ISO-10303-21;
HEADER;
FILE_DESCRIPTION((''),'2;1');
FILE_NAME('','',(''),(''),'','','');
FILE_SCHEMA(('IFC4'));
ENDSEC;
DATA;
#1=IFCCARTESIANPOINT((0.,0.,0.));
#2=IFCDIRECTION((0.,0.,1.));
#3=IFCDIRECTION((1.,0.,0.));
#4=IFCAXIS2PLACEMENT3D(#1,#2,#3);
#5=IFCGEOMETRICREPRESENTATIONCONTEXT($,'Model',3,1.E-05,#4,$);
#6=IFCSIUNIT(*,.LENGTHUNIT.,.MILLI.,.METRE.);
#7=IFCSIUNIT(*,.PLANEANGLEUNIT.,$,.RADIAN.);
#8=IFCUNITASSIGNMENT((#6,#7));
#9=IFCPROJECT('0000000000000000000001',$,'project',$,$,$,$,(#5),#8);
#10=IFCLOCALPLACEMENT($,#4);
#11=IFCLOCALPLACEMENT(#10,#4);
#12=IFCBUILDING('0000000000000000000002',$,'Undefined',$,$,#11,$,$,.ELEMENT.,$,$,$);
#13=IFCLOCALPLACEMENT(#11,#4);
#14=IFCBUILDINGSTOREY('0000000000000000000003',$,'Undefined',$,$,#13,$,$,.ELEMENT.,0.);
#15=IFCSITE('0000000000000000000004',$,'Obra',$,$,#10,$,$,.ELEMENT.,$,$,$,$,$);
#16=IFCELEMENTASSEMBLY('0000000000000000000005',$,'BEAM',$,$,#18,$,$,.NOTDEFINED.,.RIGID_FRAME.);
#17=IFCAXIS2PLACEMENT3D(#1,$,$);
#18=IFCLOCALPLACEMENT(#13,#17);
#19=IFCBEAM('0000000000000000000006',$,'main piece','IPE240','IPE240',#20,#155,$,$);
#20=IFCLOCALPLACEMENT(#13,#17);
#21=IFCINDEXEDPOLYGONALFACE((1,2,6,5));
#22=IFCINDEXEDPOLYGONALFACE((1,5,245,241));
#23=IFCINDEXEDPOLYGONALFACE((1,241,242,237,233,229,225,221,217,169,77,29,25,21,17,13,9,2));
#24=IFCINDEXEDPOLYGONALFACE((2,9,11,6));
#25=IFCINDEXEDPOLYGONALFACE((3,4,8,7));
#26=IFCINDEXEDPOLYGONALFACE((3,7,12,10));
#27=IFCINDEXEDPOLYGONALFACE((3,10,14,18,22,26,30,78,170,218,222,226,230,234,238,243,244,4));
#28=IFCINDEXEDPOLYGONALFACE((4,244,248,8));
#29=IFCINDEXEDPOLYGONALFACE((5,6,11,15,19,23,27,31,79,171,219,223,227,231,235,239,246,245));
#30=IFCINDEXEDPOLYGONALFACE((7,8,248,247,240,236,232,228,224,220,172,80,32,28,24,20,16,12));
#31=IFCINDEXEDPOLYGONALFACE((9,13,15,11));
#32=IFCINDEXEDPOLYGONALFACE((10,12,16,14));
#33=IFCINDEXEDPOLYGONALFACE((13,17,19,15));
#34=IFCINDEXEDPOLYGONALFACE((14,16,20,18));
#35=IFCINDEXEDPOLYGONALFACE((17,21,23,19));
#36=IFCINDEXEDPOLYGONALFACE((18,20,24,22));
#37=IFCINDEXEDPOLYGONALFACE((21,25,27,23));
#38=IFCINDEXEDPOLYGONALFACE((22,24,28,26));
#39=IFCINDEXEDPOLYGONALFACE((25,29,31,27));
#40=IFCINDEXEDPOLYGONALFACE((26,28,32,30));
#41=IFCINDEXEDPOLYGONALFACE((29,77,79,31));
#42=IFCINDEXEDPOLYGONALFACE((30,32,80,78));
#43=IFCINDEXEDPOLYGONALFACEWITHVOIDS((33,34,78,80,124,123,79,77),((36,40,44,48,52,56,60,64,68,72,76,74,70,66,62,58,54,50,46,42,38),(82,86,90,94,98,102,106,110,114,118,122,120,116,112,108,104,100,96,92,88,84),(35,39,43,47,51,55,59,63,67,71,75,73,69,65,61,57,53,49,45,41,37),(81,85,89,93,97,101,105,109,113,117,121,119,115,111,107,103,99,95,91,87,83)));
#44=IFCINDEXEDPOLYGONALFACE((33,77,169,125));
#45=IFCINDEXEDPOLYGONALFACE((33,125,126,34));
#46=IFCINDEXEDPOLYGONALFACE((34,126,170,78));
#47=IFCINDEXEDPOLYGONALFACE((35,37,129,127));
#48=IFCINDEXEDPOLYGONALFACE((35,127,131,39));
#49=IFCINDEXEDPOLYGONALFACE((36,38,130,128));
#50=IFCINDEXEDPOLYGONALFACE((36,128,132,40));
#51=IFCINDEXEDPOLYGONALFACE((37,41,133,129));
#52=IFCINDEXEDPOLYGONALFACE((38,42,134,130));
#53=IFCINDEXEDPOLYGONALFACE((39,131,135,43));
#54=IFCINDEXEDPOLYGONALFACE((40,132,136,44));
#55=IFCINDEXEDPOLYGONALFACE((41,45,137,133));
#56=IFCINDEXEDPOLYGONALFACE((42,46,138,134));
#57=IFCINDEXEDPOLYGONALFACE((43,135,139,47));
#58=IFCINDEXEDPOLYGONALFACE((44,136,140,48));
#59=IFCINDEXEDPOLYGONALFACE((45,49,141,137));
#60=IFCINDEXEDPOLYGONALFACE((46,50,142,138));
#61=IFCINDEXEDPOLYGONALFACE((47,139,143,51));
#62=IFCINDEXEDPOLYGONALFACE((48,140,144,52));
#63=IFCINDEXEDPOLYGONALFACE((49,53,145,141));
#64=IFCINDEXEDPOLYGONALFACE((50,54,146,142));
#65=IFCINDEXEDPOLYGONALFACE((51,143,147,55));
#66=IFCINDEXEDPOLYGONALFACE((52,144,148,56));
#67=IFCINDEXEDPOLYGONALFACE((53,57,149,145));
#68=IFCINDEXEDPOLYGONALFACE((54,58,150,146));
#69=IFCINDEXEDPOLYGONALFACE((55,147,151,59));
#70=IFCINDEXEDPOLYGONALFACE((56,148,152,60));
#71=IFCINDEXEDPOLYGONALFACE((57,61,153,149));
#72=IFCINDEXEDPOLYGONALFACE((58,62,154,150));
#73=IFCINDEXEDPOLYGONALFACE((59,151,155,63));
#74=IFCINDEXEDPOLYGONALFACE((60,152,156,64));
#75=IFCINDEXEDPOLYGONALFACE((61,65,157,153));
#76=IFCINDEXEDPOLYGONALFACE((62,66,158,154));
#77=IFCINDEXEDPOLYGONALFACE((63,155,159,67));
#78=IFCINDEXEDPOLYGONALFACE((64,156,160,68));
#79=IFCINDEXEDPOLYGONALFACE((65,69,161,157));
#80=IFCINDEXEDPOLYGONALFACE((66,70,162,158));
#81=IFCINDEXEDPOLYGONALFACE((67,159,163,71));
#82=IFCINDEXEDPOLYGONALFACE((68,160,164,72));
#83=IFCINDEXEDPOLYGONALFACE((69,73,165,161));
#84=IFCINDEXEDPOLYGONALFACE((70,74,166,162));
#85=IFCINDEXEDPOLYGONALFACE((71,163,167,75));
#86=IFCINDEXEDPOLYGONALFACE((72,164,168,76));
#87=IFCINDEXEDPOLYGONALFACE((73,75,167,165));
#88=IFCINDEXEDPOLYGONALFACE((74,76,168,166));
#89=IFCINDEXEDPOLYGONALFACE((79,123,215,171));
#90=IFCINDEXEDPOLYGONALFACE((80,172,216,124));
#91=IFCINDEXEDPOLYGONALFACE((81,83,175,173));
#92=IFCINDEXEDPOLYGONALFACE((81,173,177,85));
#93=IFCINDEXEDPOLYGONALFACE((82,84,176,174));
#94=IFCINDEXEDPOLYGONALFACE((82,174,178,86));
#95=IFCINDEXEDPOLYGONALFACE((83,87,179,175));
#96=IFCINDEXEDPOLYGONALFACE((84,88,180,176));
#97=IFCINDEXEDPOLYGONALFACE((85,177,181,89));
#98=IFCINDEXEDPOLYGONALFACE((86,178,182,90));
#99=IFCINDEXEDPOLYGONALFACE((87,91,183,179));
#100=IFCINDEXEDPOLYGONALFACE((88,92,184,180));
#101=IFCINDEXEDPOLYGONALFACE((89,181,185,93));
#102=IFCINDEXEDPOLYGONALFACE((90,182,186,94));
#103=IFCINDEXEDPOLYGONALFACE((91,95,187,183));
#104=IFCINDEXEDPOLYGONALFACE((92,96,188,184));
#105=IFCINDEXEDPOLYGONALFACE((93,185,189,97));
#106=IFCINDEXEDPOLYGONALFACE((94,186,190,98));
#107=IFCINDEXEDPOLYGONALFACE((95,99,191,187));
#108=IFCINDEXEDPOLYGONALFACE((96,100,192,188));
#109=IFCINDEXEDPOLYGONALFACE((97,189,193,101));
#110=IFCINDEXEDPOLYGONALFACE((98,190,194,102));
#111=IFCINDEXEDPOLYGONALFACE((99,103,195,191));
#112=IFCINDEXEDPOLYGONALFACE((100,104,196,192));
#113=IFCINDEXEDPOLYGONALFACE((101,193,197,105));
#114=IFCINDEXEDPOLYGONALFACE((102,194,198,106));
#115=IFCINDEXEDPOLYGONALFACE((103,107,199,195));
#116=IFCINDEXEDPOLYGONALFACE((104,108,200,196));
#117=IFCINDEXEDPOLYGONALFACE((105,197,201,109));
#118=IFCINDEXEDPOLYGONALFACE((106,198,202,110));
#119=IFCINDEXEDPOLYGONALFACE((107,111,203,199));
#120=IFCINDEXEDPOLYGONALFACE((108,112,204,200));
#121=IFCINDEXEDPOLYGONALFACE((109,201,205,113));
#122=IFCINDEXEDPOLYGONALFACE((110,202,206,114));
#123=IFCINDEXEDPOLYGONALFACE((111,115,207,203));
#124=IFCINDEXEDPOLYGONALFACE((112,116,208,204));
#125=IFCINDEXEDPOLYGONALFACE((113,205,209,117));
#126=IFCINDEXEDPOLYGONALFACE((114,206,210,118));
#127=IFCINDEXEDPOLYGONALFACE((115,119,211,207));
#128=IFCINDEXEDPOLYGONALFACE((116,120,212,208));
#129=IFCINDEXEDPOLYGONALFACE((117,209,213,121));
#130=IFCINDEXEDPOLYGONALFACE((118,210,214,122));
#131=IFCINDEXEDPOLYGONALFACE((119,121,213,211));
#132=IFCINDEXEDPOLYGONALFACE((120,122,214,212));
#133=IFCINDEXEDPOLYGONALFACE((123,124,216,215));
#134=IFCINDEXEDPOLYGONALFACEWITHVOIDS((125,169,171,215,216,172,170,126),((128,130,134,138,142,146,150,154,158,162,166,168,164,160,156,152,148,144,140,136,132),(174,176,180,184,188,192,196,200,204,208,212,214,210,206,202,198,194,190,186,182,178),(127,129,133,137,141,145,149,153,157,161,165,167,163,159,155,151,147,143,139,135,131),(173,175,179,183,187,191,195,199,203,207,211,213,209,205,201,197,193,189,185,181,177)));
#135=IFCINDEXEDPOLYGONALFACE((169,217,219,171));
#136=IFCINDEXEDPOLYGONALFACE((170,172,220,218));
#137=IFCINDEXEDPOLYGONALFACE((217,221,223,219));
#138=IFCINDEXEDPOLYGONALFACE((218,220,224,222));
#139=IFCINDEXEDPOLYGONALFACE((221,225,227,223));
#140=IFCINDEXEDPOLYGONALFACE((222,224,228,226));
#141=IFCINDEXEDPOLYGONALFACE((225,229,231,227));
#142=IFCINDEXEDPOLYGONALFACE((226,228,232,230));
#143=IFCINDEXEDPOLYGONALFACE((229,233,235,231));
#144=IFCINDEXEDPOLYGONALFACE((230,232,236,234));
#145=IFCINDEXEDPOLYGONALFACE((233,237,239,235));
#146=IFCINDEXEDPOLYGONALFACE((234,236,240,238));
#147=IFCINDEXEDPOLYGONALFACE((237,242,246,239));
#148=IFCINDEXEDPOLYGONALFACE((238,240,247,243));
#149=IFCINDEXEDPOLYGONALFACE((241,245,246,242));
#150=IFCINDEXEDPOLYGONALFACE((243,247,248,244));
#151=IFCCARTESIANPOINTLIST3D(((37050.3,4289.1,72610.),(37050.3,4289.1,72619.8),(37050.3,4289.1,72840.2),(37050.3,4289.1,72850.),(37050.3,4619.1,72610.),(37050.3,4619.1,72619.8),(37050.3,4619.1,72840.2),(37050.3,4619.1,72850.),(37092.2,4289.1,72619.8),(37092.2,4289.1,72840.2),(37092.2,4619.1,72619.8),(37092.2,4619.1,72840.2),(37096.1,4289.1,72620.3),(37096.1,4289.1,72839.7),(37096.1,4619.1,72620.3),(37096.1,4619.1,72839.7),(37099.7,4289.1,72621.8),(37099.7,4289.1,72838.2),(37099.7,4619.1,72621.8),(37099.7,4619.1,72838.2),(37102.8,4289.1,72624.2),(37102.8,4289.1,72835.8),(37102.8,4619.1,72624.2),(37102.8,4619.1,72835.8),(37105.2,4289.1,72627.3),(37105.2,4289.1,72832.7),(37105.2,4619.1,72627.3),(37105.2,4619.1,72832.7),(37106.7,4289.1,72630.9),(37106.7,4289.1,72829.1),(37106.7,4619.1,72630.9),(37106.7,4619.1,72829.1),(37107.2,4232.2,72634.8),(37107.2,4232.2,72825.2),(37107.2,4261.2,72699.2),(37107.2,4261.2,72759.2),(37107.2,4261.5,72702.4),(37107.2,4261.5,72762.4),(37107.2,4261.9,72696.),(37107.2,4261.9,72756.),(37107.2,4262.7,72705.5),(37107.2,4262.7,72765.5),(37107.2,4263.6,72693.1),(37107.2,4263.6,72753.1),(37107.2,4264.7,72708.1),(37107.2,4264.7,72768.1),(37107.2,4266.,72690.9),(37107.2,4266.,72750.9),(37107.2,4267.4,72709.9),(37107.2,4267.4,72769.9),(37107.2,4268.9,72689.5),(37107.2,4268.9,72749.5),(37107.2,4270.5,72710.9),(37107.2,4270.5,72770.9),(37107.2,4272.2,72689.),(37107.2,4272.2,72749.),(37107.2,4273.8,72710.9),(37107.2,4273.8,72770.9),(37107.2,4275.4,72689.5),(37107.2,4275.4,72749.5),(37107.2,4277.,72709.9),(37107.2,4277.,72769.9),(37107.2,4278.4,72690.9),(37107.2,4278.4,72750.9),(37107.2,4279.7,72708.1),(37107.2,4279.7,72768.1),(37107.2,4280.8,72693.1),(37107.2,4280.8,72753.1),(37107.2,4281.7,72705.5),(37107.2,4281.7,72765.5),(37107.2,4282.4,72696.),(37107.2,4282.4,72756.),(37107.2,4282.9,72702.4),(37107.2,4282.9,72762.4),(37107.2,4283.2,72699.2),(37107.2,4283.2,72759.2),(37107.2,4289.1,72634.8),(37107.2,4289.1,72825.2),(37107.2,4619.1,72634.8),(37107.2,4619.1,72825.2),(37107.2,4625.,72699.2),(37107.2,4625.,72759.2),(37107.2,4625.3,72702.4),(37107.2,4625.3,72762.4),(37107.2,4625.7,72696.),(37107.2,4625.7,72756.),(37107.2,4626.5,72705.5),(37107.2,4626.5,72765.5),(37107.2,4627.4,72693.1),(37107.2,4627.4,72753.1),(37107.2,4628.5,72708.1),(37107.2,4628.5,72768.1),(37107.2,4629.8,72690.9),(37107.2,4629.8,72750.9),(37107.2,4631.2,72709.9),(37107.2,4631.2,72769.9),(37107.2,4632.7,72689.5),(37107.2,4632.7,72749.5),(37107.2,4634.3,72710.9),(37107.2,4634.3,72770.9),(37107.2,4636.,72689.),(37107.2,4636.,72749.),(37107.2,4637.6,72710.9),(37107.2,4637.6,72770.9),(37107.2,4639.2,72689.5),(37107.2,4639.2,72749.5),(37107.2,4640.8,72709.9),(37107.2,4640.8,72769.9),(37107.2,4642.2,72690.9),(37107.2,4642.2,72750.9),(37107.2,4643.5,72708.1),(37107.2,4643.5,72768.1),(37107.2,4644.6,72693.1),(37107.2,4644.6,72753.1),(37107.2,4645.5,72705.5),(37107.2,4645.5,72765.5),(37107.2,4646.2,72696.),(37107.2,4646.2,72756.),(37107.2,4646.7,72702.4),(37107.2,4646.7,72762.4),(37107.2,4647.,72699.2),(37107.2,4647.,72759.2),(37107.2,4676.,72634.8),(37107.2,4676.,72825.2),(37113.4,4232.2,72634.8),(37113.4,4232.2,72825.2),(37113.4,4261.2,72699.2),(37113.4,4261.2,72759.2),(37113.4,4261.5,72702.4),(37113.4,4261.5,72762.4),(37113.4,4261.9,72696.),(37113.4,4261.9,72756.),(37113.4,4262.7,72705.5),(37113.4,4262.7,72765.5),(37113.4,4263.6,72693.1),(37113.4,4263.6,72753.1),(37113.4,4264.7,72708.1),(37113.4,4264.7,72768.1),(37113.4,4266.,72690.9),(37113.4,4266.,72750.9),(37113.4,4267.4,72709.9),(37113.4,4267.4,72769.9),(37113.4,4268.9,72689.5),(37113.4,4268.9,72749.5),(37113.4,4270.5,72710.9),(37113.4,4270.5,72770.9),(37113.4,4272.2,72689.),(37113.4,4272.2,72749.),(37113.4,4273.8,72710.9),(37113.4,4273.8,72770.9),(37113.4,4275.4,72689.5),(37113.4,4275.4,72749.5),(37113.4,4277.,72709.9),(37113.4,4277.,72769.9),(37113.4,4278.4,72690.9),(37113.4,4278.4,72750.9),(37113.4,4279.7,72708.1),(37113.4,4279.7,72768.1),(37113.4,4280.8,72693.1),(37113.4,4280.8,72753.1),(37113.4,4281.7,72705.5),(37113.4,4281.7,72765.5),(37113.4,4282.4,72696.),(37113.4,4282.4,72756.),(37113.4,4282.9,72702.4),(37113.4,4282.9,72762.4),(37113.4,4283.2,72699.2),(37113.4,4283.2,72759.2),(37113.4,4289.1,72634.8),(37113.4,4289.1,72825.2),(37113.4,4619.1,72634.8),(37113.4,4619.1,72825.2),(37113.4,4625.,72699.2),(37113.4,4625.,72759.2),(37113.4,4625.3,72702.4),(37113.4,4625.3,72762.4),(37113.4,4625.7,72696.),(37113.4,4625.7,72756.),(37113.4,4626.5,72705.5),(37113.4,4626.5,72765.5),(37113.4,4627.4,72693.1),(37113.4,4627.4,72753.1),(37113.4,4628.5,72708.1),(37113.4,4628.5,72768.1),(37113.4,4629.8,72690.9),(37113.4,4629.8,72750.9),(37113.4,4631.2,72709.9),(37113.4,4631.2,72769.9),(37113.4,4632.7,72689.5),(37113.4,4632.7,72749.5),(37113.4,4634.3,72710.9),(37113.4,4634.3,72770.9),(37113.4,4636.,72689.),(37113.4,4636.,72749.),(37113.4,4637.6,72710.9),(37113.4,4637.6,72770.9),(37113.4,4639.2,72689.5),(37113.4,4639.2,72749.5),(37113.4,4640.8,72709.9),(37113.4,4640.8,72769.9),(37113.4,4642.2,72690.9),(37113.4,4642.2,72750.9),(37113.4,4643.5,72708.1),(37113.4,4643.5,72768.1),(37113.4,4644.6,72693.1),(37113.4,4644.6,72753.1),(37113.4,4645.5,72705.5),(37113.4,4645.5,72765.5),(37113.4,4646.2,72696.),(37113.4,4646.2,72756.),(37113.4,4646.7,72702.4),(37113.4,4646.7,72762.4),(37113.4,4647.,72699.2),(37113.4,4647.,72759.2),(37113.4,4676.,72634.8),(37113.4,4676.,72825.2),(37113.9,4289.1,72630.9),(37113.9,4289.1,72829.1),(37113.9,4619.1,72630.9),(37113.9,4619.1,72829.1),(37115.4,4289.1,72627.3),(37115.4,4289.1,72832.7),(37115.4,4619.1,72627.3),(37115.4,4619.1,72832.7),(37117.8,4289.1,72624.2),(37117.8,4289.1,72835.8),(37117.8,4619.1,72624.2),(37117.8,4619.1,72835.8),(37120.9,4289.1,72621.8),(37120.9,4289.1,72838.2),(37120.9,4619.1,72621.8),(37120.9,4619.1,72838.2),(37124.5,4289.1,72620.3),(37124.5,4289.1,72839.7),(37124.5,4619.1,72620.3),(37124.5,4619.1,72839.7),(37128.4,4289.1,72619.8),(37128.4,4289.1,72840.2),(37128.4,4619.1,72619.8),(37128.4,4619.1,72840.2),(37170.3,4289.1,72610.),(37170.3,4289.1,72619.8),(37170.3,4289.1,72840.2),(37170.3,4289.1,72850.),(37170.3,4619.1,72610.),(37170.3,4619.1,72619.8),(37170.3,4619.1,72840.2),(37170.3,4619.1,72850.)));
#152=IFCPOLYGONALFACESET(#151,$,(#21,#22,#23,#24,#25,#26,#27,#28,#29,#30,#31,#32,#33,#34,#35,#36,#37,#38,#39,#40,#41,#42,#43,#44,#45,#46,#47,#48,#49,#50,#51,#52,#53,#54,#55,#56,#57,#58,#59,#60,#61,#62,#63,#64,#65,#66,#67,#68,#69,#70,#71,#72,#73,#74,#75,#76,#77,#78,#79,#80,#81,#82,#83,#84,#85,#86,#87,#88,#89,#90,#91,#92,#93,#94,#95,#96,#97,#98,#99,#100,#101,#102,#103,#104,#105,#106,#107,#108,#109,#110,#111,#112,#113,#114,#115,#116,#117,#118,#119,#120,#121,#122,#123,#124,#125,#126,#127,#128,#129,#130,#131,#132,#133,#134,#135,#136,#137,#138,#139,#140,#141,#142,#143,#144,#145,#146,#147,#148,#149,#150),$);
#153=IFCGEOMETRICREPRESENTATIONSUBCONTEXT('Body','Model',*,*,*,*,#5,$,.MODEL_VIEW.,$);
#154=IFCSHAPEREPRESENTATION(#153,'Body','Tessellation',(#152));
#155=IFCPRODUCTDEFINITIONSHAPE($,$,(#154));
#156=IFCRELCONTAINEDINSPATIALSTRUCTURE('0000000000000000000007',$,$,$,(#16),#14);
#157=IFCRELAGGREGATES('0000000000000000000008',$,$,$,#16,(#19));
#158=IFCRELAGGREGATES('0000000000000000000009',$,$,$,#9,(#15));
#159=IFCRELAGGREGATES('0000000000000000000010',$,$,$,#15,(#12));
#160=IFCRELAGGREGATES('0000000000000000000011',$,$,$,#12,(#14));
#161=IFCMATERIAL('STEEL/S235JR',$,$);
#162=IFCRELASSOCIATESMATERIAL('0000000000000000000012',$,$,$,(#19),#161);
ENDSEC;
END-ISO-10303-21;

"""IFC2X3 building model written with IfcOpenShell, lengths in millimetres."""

from ifc_helpers import new_model, si_unit, frame, origin_with_axes, origin_2d_with_axis, place, context, subcontext, project, spatial, rectangle, circle, i_section, extrude, clip, halfspace, source, transform, mapped, material, element, aggregate, save


model = new_model("IFC2X3")

# Units and contexts
model_context = context("Model", 3, precision=1e-05, world=origin_with_axes())
body_context = subcontext(model_context, "Body", "Model", "MODEL_VIEW")
ifc_project = project(units=[si_unit("LENGTHUNIT", "METRE", prefix="MILLI"), si_unit("PLANEANGLEUNIT", "RADIAN")], contexts=[model_context])

# Site, building, storey
site_placement = place(None, origin_with_axes())
site = spatial("IfcSite", under=ifc_project, at=site_placement, Name="Obra", CompositionType="ELEMENT")
building_placement = place(site_placement, origin_with_axes())
building = spatial("IfcBuilding", under=site, at=building_placement, Name="Undefined", CompositionType="ELEMENT")
storey_placement = place(building_placement, origin_with_axes())
storey = spatial("IfcBuildingStorey", under=building, at=storey_placement, Name="Undefined", CompositionType="ELEMENT", Elevation=0.0)

# Element assembly, beam, openings
assembly_1_placement = place(storey_placement, origin_with_axes())
assembly_1 = element("IfcElementAssembly", 1, at=assembly_1_placement, inside=storey, Name="BEAM", AssemblyPlace="NOTDEFINED", PredefinedType="RIGID_FRAME")
ifc_material_1 = material(Name="STEEL/S235JR")
beam_1_placement = place(assembly_1_placement, frame((37110.3, 4299.1, 72730.0), z_axis=(0.0, 0.0, 1.0), x_axis=(0.0, 1.0, 0.0)))
beam_1 = element("IfcBeam", 2, at=beam_1_placement, material=ifc_material_1, Name="main piece", Description="IPE240", ObjectType="IPE240", context=body_context, shape_type="Clipping", body=[
    clip(clip(extrude(i_section(OverallWidth=120.0, OverallDepth=240.0, WebThickness=6.2, FlangeThickness=9.8, FilletRadius=15.0, at=origin_2d_with_axis()), frame((376.9, 0.0, 0.0), z_axis=(-1.0, 0.0, 0.0), x_axis=(0.0, -1.0, 0.0)), (0.0, 0.0, 1.0), 443.8), halfspace(frame((376.9, 0.0, -220.0), z_axis=(-1.0, 0.0, 0.0), x_axis=(0.0, 1.0, 0.0)), True)), halfspace(frame((-66.9, 0.0, -220.0), z_axis=(1.0, 0.0, 0.0), x_axis=(0.0, -1.0, 0.0)), True)),
])
opening_1_placement = place(assembly_1_placement, frame((37110.3, 4299.1, 72730.0), z_axis=(0.0, 0.0, 1.0), x_axis=(0.0, 1.0, 0.0)))
element("IfcOpeningElement", 3, at=opening_1_placement, cuts=beam_1, ObjectType="Recess", context=body_context, shape_type="SweptSolid", body=[
    extrude(rectangle(XDim=25.8, YDim=68.9, at=origin_2d_with_axis()), frame((354.4, 61.0, -108.1), z_axis=(0.0, -1.0, 0.0), x_axis=(0.0, 0.0, -1.0)), (0.0, 0.0, 1.0), 122.0),
])
opening_2_placement = place(assembly_1_placement, frame((37110.3, 4299.1, 72730.0), z_axis=(0.0, 0.0, 1.0), x_axis=(0.0, 1.0, 0.0)))
element("IfcOpeningElement", 4, at=opening_2_placement, cuts=beam_1, ObjectType="Recess", context=body_context, shape_type="SweptSolid", body=[
    extrude(rectangle(XDim=25.8, YDim=68.9, at=origin_2d_with_axis()), frame((354.4, 61.0, 108.1), z_axis=(0.0, -1.0, 0.0), x_axis=(0.0, 0.0, -1.0)), (0.0, 0.0, 1.0), 122.0),
])
opening_3_placement = place(assembly_1_placement, frame((37110.3, 4299.1, 72730.0), z_axis=(0.0, 0.0, 1.0), x_axis=(0.0, 1.0, 0.0)))
element("IfcOpeningElement", 5, at=opening_3_placement, cuts=beam_1, ObjectType="Recess", context=body_context, shape_type="SweptSolid", body=[
    extrude(rectangle(XDim=25.8, YDim=68.9, at=origin_2d_with_axis()), frame((-44.4, -61.0, -108.1), z_axis=(0.0, 1.0, 0.0), x_axis=(0.0, 0.0, -1.0)), (0.0, 0.0, 1.0), 122.0),
])
opening_4_placement = place(assembly_1_placement, frame((37110.3, 4299.1, 72730.0), z_axis=(0.0, 0.0, 1.0), x_axis=(0.0, 1.0, 0.0)))
element("IfcOpeningElement", 6, at=opening_4_placement, cuts=beam_1, ObjectType="Recess", context=body_context, shape_type="SweptSolid", body=[
    extrude(rectangle(XDim=25.8, YDim=68.9, at=origin_2d_with_axis()), frame((-44.4, -61.0, 108.1), z_axis=(0.0, 1.0, 0.0), x_axis=(0.0, 0.0, -1.0)), (0.0, 0.0, 1.0), 122.0),
])
shared_shape_1 = source(origin_with_axes(), body_context, "Body", "SweptSolid", [
    extrude(circle(Radius=11.0, at=origin_2d_with_axis()), frame((0.0, -3.2, 0.0), z_axis=(0.0, 1.0, 0.0), x_axis=(1.0, 0.0, 0.0)), (0.0, 0.0, 1.0), 6.4),
])
opening_5_placement = place(assembly_1_placement, frame((37110.3, 4676.0, 72850.0), z_axis=(0.0, -1.0, 0.0), x_axis=(0.0, 0.0, -1.0)))
element("IfcOpeningElement", 7, at=opening_5_placement, cuts=beam_1, ObjectType="Opening", context=body_context, shape_type="MappedRepresentation", body=[
    mapped(shared_shape_1, transform((90.0, 0.0, 40.0))),
    mapped(shared_shape_1, transform((150.0, 0.0, 40.0))),
])
opening_6_placement = place(assembly_1_placement, frame((37110.3, 4232.2, 72850.0), z_axis=(0.0, 1.0, 0.0), x_axis=(0.0, 0.0, -1.0)))
element("IfcOpeningElement", 8, at=opening_6_placement, cuts=beam_1, ObjectType="Opening", context=body_context, shape_type="MappedRepresentation", body=[
    mapped(shared_shape_1, transform((90.0, 0.0, 40.0))),
    mapped(shared_shape_1, transform((150.0, 0.0, 40.0))),
])
aggregate(assembly_1, [beam_1])

save(model, "model.ifc")
